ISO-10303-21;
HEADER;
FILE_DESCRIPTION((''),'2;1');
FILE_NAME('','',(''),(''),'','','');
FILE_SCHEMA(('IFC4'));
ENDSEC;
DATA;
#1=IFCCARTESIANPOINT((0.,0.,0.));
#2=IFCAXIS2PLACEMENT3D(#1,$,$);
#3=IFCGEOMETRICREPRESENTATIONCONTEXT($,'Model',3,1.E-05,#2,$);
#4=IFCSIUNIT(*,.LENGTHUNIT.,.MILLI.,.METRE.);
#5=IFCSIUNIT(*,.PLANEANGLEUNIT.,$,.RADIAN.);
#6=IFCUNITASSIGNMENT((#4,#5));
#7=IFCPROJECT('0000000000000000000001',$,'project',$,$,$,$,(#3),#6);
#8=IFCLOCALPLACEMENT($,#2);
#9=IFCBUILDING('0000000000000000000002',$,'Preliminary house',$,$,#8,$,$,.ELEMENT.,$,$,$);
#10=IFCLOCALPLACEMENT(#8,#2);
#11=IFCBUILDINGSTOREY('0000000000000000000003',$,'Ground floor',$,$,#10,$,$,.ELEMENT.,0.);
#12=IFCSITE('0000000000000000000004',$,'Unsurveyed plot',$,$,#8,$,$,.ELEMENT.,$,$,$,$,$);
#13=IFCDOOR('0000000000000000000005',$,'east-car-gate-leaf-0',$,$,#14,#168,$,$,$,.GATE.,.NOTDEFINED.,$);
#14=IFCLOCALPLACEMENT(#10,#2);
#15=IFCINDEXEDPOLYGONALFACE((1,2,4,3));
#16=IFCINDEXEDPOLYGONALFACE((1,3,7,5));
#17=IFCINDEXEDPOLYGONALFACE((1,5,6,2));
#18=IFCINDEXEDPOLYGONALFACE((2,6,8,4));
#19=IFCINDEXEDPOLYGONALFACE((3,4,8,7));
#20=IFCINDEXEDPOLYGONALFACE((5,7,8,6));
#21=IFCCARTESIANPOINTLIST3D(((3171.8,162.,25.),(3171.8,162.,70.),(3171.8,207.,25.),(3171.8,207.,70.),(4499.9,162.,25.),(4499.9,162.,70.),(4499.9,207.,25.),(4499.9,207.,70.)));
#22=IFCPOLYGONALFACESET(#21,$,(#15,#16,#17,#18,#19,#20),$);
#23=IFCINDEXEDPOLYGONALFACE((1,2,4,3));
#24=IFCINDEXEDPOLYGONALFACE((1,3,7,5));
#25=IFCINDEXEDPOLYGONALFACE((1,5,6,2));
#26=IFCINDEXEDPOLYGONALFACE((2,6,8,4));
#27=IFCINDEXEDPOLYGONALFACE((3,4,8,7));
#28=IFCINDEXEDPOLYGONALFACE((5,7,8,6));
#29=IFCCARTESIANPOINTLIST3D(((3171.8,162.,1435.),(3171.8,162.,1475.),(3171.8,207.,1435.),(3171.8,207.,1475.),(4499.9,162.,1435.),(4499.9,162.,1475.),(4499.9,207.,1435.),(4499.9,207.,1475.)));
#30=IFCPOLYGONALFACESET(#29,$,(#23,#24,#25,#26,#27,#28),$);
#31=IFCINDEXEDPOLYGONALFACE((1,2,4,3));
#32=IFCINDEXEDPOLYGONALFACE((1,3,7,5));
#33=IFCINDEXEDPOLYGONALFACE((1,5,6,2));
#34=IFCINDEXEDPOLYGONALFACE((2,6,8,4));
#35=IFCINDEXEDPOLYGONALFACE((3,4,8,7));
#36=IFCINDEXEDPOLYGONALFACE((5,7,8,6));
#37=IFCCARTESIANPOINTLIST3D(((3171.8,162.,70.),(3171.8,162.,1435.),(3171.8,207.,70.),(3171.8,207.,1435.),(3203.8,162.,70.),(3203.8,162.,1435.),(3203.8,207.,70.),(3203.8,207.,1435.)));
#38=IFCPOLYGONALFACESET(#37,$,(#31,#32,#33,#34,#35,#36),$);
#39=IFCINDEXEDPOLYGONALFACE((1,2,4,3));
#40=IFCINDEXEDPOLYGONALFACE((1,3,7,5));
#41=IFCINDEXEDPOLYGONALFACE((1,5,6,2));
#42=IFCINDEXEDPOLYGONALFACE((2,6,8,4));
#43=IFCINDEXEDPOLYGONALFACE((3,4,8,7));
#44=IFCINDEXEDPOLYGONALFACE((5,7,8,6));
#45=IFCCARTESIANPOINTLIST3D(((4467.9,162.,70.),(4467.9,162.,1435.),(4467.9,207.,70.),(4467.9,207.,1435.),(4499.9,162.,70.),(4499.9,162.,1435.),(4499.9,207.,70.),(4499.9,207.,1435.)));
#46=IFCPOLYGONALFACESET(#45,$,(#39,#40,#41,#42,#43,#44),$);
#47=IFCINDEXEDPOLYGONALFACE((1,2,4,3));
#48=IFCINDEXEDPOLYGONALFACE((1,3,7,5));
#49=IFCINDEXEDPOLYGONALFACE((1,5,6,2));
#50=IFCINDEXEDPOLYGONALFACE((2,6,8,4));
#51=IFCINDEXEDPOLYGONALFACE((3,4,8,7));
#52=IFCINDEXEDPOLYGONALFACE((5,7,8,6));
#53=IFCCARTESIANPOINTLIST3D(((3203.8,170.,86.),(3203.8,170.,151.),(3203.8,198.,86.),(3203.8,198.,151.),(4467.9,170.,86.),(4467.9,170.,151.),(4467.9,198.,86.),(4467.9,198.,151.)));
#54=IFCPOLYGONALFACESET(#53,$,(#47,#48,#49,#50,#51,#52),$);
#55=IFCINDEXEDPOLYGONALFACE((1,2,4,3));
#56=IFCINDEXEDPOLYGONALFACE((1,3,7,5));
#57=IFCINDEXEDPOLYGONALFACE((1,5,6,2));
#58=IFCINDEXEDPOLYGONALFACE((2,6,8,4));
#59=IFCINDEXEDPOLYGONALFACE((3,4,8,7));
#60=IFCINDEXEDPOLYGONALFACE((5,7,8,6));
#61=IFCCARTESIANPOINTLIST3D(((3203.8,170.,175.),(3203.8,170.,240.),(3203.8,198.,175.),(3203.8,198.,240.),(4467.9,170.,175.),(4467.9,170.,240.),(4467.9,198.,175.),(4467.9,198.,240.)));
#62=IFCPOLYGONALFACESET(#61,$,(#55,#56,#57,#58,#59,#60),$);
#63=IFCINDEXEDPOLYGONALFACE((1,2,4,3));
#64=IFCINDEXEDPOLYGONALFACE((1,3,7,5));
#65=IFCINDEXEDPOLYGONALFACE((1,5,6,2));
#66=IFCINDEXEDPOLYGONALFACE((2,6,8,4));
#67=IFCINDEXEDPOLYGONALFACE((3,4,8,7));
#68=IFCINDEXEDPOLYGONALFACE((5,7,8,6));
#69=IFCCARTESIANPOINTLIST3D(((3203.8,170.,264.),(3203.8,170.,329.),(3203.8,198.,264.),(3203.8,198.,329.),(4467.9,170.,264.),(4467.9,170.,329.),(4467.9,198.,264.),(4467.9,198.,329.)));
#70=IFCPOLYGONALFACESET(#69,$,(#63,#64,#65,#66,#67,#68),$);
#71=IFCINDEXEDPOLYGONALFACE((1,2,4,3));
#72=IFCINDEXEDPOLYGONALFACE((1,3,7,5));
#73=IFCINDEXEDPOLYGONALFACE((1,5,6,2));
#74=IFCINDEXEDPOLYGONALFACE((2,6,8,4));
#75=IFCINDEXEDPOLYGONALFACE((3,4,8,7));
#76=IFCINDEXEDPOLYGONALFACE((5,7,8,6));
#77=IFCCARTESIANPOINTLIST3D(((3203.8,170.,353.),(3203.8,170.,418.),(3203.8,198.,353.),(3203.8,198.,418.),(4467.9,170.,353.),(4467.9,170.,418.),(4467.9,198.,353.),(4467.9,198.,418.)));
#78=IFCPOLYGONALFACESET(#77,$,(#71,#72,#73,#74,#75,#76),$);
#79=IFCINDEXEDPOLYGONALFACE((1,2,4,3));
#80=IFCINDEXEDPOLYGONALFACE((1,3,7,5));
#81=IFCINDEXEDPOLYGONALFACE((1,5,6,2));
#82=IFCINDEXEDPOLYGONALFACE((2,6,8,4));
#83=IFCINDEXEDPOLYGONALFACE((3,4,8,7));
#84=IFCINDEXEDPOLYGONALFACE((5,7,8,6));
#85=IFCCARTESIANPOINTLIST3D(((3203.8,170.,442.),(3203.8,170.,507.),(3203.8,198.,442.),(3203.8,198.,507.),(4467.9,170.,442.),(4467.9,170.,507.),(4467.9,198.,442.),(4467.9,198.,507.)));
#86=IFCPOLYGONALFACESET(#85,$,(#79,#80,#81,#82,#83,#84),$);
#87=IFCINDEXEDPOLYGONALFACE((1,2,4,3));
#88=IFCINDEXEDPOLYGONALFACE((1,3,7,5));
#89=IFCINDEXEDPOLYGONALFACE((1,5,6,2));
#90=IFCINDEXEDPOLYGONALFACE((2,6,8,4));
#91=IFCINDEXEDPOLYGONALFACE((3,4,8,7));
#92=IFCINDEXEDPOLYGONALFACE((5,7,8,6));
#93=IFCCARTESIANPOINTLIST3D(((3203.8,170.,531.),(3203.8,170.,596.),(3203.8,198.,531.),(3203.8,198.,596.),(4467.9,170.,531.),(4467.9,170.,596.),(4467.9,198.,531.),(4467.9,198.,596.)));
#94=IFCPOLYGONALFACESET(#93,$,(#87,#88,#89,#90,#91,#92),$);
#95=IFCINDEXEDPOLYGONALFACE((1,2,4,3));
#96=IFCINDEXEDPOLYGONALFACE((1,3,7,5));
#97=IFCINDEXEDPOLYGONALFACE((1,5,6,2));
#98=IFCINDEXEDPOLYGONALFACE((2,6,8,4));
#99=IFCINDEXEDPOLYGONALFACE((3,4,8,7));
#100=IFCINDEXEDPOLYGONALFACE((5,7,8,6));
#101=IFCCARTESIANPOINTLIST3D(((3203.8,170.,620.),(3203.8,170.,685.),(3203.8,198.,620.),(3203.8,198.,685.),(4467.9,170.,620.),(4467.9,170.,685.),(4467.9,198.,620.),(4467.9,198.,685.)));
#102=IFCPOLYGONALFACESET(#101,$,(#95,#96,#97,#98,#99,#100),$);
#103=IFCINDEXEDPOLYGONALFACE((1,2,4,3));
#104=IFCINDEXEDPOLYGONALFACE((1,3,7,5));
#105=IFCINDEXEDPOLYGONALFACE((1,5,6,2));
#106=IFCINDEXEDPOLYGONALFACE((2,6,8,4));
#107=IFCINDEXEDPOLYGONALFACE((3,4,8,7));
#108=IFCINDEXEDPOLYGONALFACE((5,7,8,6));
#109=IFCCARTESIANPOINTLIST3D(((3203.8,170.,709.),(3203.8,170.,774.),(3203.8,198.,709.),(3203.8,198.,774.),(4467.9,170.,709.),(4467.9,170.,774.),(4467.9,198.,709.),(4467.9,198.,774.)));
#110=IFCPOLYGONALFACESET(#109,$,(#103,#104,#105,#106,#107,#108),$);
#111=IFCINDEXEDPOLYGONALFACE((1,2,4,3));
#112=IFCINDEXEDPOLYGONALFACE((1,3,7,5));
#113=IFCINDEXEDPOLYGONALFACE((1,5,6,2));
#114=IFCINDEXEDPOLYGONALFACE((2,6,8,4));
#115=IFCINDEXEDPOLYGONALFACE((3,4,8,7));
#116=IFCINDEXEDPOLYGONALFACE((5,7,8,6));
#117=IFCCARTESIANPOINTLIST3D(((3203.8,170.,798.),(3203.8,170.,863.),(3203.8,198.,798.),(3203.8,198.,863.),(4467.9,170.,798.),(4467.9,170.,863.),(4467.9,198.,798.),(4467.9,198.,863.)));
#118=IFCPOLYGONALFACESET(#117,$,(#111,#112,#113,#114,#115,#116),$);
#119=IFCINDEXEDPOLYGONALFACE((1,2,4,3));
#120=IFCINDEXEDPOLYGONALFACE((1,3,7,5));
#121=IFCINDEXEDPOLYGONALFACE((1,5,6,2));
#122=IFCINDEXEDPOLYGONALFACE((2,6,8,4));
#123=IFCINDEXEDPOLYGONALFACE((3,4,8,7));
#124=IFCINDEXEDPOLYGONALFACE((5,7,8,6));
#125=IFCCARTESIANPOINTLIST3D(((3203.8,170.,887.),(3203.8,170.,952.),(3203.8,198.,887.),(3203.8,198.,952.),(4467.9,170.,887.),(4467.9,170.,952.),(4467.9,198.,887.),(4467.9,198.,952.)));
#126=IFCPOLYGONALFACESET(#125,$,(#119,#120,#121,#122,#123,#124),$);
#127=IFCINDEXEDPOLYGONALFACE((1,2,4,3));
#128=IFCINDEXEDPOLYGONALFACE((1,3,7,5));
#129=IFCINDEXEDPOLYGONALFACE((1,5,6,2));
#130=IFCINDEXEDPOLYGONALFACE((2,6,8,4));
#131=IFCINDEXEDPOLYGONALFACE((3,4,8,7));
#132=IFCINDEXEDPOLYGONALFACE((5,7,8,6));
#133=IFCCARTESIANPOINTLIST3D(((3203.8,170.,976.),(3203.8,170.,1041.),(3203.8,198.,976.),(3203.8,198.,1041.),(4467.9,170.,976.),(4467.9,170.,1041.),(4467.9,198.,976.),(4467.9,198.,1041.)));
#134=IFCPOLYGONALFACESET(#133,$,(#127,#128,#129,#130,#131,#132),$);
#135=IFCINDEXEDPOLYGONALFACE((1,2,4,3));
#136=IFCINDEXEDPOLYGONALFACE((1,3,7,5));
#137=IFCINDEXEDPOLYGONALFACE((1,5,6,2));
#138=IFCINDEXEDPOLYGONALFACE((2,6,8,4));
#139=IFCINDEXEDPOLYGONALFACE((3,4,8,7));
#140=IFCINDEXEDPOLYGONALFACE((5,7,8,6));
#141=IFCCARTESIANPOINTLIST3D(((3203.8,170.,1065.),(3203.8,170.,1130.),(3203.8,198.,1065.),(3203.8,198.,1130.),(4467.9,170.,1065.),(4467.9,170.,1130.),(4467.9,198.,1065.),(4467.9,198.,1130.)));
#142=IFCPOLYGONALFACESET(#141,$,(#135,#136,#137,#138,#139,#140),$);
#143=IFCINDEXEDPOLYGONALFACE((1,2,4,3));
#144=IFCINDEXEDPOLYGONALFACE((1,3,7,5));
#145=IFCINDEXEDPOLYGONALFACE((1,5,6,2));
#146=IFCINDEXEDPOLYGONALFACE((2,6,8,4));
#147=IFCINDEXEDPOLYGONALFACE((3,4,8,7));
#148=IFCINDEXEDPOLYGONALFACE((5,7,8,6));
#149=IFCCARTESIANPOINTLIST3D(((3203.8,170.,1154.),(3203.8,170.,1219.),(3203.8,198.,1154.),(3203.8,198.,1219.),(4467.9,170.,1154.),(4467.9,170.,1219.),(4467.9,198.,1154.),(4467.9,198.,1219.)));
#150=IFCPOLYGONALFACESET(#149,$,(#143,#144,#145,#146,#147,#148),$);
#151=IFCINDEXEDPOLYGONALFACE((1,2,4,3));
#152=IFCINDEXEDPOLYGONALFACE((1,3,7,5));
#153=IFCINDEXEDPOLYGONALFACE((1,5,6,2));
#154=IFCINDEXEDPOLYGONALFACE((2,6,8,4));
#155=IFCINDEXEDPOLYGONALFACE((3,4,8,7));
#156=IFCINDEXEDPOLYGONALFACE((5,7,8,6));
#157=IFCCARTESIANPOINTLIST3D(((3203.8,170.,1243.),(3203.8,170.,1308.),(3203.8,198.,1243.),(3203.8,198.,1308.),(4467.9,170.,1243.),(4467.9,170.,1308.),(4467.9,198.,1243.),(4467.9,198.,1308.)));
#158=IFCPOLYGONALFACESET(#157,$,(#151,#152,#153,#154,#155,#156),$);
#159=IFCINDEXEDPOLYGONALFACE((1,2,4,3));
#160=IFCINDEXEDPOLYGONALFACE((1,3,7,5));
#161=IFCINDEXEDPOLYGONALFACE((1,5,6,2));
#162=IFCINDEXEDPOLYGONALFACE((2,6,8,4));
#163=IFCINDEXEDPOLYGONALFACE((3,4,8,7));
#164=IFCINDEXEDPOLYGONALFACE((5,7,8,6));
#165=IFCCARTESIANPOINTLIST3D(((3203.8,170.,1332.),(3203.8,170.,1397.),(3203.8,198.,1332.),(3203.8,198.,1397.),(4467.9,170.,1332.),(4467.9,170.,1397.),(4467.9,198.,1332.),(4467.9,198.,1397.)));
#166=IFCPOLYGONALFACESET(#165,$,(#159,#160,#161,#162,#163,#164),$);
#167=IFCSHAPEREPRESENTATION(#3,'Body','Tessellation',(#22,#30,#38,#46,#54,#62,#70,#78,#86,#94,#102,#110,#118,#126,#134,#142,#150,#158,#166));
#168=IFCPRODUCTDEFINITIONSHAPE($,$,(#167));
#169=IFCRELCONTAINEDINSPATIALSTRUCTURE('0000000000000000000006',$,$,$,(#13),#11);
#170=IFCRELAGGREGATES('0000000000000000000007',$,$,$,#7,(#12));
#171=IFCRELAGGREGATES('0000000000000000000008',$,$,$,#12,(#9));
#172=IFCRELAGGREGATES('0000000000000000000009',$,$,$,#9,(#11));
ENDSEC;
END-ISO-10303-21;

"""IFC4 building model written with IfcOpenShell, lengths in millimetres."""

from ifc_helpers import new_model, si_unit, frame, origin, place, context, project, spatial, polyline, outline, extrude, element, save


model = new_model("IFC4")

# Units and contexts
model_context = context("Model", 3, precision=1e-05, world=origin())
ifc_project = project(units=[si_unit("LENGTHUNIT", "METRE", prefix="MILLI"), si_unit("PLANEANGLEUNIT", "RADIAN")], contexts=[model_context])

# Site, building, storey
placement_1 = place(None, origin())
site = spatial("IfcSite", under=ifc_project, at=placement_1, Name="Unsurveyed plot", CompositionType="ELEMENT")
building = spatial("IfcBuilding", under=site, at=placement_1, Name="Preliminary house", CompositionType="ELEMENT")
placement_2 = place(placement_1, origin())
storey = spatial("IfcBuildingStorey", under=building, at=placement_2, Name="Ground floor", CompositionType="ELEMENT", Elevation=0.0)

# Door
element("IfcDoor", 1, at=placement_2, inside=storey, Name="east-car-gate-leaf-0", OperationType="NOTDEFINED", PredefinedType="GATE", context=model_context, shape_type="SweptSolid", body=[
    extrude(outline(polyline([(4499.9, 162.0), (4499.9, 207.0), (3171.8, 207.0), (3171.8, 162.0), (4499.9, 162.0)])), frame((0.0, 0.0, 25.0)), (0.0, 0.0, 1.0), 45.0),
    extrude(outline(polyline([(4499.9, 162.0), (4499.9, 207.0), (3171.8, 207.0), (3171.8, 162.0), (4499.9, 162.0)])), frame((0.0, 0.0, 1435.0)), (0.0, 0.0, 1.0), 40.0),
    extrude(outline(polyline([(3203.8, 162.0), (3203.8, 207.0), (3171.8, 207.0), (3171.8, 162.0), (3203.8, 162.0)])), frame((0.0, 0.0, 70.0)), (0.0, 0.0, 1.0), 1365.0),
    extrude(outline(polyline([(4499.9, 162.0), (4499.9, 207.0), (4467.9, 207.0), (4467.9, 162.0), (4499.9, 162.0)])), frame((0.0, 0.0, 70.0)), (0.0, 0.0, 1.0), 1365.0),
    extrude(outline(polyline([(4467.9, 170.0), (4467.9, 198.0), (3203.8, 198.0), (3203.8, 170.0), (4467.9, 170.0)])), frame((0.0, 0.0, 86.0)), (0.0, 0.0, 1.0), 65.0),
    extrude(outline(polyline([(4467.9, 170.0), (4467.9, 198.0), (3203.8, 198.0), (3203.8, 170.0), (4467.9, 170.0)])), frame((0.0, 0.0, 175.0)), (0.0, 0.0, 1.0), 65.0),
    extrude(outline(polyline([(4467.9, 170.0), (4467.9, 198.0), (3203.8, 198.0), (3203.8, 170.0), (4467.9, 170.0)])), frame((0.0, 0.0, 264.0)), (0.0, 0.0, 1.0), 65.0),
    extrude(outline(polyline([(4467.9, 170.0), (4467.9, 198.0), (3203.8, 198.0), (3203.8, 170.0), (4467.9, 170.0)])), frame((0.0, 0.0, 353.0)), (0.0, 0.0, 1.0), 65.0),
    extrude(outline(polyline([(4467.9, 170.0), (4467.9, 198.0), (3203.8, 198.0), (3203.8, 170.0), (4467.9, 170.0)])), frame((0.0, 0.0, 442.0)), (0.0, 0.0, 1.0), 65.0),
    extrude(outline(polyline([(4467.9, 170.0), (4467.9, 198.0), (3203.8, 198.0), (3203.8, 170.0), (4467.9, 170.0)])), frame((0.0, 0.0, 531.0)), (0.0, 0.0, 1.0), 65.0),
    extrude(outline(polyline([(4467.9, 170.0), (4467.9, 198.0), (3203.8, 198.0), (3203.8, 170.0), (4467.9, 170.0)])), frame((0.0, 0.0, 620.0)), (0.0, 0.0, 1.0), 65.0),
    extrude(outline(polyline([(4467.9, 170.0), (4467.9, 198.0), (3203.8, 198.0), (3203.8, 170.0), (4467.9, 170.0)])), frame((0.0, 0.0, 709.0)), (0.0, 0.0, 1.0), 65.0),
    extrude(outline(polyline([(4467.9, 170.0), (4467.9, 198.0), (3203.8, 198.0), (3203.8, 170.0), (4467.9, 170.0)])), frame((0.0, 0.0, 798.0)), (0.0, 0.0, 1.0), 65.0),
    extrude(outline(polyline([(4467.9, 170.0), (4467.9, 198.0), (3203.8, 198.0), (3203.8, 170.0), (4467.9, 170.0)])), frame((0.0, 0.0, 887.0)), (0.0, 0.0, 1.0), 65.0),
    extrude(outline(polyline([(4467.9, 170.0), (4467.9, 198.0), (3203.8, 198.0), (3203.8, 170.0), (4467.9, 170.0)])), frame((0.0, 0.0, 976.0)), (0.0, 0.0, 1.0), 65.0),
    extrude(outline(polyline([(4467.9, 170.0), (4467.9, 198.0), (3203.8, 198.0), (3203.8, 170.0), (4467.9, 170.0)])), frame((0.0, 0.0, 1065.0)), (0.0, 0.0, 1.0), 65.0),
    extrude(outline(polyline([(4467.9, 170.0), (4467.9, 198.0), (3203.8, 198.0), (3203.8, 170.0), (4467.9, 170.0)])), frame((0.0, 0.0, 1154.0)), (0.0, 0.0, 1.0), 65.0),
    extrude(outline(polyline([(4467.9, 170.0), (4467.9, 198.0), (3203.8, 198.0), (3203.8, 170.0), (4467.9, 170.0)])), frame((0.0, 0.0, 1243.0)), (0.0, 0.0, 1.0), 65.0),
    extrude(outline(polyline([(4467.9, 170.0), (4467.9, 198.0), (3203.8, 198.0), (3203.8, 170.0), (4467.9, 170.0)])), frame((0.0, 0.0, 1332.0)), (0.0, 0.0, 1.0), 65.0),
])

save(model, "model.ifc")
